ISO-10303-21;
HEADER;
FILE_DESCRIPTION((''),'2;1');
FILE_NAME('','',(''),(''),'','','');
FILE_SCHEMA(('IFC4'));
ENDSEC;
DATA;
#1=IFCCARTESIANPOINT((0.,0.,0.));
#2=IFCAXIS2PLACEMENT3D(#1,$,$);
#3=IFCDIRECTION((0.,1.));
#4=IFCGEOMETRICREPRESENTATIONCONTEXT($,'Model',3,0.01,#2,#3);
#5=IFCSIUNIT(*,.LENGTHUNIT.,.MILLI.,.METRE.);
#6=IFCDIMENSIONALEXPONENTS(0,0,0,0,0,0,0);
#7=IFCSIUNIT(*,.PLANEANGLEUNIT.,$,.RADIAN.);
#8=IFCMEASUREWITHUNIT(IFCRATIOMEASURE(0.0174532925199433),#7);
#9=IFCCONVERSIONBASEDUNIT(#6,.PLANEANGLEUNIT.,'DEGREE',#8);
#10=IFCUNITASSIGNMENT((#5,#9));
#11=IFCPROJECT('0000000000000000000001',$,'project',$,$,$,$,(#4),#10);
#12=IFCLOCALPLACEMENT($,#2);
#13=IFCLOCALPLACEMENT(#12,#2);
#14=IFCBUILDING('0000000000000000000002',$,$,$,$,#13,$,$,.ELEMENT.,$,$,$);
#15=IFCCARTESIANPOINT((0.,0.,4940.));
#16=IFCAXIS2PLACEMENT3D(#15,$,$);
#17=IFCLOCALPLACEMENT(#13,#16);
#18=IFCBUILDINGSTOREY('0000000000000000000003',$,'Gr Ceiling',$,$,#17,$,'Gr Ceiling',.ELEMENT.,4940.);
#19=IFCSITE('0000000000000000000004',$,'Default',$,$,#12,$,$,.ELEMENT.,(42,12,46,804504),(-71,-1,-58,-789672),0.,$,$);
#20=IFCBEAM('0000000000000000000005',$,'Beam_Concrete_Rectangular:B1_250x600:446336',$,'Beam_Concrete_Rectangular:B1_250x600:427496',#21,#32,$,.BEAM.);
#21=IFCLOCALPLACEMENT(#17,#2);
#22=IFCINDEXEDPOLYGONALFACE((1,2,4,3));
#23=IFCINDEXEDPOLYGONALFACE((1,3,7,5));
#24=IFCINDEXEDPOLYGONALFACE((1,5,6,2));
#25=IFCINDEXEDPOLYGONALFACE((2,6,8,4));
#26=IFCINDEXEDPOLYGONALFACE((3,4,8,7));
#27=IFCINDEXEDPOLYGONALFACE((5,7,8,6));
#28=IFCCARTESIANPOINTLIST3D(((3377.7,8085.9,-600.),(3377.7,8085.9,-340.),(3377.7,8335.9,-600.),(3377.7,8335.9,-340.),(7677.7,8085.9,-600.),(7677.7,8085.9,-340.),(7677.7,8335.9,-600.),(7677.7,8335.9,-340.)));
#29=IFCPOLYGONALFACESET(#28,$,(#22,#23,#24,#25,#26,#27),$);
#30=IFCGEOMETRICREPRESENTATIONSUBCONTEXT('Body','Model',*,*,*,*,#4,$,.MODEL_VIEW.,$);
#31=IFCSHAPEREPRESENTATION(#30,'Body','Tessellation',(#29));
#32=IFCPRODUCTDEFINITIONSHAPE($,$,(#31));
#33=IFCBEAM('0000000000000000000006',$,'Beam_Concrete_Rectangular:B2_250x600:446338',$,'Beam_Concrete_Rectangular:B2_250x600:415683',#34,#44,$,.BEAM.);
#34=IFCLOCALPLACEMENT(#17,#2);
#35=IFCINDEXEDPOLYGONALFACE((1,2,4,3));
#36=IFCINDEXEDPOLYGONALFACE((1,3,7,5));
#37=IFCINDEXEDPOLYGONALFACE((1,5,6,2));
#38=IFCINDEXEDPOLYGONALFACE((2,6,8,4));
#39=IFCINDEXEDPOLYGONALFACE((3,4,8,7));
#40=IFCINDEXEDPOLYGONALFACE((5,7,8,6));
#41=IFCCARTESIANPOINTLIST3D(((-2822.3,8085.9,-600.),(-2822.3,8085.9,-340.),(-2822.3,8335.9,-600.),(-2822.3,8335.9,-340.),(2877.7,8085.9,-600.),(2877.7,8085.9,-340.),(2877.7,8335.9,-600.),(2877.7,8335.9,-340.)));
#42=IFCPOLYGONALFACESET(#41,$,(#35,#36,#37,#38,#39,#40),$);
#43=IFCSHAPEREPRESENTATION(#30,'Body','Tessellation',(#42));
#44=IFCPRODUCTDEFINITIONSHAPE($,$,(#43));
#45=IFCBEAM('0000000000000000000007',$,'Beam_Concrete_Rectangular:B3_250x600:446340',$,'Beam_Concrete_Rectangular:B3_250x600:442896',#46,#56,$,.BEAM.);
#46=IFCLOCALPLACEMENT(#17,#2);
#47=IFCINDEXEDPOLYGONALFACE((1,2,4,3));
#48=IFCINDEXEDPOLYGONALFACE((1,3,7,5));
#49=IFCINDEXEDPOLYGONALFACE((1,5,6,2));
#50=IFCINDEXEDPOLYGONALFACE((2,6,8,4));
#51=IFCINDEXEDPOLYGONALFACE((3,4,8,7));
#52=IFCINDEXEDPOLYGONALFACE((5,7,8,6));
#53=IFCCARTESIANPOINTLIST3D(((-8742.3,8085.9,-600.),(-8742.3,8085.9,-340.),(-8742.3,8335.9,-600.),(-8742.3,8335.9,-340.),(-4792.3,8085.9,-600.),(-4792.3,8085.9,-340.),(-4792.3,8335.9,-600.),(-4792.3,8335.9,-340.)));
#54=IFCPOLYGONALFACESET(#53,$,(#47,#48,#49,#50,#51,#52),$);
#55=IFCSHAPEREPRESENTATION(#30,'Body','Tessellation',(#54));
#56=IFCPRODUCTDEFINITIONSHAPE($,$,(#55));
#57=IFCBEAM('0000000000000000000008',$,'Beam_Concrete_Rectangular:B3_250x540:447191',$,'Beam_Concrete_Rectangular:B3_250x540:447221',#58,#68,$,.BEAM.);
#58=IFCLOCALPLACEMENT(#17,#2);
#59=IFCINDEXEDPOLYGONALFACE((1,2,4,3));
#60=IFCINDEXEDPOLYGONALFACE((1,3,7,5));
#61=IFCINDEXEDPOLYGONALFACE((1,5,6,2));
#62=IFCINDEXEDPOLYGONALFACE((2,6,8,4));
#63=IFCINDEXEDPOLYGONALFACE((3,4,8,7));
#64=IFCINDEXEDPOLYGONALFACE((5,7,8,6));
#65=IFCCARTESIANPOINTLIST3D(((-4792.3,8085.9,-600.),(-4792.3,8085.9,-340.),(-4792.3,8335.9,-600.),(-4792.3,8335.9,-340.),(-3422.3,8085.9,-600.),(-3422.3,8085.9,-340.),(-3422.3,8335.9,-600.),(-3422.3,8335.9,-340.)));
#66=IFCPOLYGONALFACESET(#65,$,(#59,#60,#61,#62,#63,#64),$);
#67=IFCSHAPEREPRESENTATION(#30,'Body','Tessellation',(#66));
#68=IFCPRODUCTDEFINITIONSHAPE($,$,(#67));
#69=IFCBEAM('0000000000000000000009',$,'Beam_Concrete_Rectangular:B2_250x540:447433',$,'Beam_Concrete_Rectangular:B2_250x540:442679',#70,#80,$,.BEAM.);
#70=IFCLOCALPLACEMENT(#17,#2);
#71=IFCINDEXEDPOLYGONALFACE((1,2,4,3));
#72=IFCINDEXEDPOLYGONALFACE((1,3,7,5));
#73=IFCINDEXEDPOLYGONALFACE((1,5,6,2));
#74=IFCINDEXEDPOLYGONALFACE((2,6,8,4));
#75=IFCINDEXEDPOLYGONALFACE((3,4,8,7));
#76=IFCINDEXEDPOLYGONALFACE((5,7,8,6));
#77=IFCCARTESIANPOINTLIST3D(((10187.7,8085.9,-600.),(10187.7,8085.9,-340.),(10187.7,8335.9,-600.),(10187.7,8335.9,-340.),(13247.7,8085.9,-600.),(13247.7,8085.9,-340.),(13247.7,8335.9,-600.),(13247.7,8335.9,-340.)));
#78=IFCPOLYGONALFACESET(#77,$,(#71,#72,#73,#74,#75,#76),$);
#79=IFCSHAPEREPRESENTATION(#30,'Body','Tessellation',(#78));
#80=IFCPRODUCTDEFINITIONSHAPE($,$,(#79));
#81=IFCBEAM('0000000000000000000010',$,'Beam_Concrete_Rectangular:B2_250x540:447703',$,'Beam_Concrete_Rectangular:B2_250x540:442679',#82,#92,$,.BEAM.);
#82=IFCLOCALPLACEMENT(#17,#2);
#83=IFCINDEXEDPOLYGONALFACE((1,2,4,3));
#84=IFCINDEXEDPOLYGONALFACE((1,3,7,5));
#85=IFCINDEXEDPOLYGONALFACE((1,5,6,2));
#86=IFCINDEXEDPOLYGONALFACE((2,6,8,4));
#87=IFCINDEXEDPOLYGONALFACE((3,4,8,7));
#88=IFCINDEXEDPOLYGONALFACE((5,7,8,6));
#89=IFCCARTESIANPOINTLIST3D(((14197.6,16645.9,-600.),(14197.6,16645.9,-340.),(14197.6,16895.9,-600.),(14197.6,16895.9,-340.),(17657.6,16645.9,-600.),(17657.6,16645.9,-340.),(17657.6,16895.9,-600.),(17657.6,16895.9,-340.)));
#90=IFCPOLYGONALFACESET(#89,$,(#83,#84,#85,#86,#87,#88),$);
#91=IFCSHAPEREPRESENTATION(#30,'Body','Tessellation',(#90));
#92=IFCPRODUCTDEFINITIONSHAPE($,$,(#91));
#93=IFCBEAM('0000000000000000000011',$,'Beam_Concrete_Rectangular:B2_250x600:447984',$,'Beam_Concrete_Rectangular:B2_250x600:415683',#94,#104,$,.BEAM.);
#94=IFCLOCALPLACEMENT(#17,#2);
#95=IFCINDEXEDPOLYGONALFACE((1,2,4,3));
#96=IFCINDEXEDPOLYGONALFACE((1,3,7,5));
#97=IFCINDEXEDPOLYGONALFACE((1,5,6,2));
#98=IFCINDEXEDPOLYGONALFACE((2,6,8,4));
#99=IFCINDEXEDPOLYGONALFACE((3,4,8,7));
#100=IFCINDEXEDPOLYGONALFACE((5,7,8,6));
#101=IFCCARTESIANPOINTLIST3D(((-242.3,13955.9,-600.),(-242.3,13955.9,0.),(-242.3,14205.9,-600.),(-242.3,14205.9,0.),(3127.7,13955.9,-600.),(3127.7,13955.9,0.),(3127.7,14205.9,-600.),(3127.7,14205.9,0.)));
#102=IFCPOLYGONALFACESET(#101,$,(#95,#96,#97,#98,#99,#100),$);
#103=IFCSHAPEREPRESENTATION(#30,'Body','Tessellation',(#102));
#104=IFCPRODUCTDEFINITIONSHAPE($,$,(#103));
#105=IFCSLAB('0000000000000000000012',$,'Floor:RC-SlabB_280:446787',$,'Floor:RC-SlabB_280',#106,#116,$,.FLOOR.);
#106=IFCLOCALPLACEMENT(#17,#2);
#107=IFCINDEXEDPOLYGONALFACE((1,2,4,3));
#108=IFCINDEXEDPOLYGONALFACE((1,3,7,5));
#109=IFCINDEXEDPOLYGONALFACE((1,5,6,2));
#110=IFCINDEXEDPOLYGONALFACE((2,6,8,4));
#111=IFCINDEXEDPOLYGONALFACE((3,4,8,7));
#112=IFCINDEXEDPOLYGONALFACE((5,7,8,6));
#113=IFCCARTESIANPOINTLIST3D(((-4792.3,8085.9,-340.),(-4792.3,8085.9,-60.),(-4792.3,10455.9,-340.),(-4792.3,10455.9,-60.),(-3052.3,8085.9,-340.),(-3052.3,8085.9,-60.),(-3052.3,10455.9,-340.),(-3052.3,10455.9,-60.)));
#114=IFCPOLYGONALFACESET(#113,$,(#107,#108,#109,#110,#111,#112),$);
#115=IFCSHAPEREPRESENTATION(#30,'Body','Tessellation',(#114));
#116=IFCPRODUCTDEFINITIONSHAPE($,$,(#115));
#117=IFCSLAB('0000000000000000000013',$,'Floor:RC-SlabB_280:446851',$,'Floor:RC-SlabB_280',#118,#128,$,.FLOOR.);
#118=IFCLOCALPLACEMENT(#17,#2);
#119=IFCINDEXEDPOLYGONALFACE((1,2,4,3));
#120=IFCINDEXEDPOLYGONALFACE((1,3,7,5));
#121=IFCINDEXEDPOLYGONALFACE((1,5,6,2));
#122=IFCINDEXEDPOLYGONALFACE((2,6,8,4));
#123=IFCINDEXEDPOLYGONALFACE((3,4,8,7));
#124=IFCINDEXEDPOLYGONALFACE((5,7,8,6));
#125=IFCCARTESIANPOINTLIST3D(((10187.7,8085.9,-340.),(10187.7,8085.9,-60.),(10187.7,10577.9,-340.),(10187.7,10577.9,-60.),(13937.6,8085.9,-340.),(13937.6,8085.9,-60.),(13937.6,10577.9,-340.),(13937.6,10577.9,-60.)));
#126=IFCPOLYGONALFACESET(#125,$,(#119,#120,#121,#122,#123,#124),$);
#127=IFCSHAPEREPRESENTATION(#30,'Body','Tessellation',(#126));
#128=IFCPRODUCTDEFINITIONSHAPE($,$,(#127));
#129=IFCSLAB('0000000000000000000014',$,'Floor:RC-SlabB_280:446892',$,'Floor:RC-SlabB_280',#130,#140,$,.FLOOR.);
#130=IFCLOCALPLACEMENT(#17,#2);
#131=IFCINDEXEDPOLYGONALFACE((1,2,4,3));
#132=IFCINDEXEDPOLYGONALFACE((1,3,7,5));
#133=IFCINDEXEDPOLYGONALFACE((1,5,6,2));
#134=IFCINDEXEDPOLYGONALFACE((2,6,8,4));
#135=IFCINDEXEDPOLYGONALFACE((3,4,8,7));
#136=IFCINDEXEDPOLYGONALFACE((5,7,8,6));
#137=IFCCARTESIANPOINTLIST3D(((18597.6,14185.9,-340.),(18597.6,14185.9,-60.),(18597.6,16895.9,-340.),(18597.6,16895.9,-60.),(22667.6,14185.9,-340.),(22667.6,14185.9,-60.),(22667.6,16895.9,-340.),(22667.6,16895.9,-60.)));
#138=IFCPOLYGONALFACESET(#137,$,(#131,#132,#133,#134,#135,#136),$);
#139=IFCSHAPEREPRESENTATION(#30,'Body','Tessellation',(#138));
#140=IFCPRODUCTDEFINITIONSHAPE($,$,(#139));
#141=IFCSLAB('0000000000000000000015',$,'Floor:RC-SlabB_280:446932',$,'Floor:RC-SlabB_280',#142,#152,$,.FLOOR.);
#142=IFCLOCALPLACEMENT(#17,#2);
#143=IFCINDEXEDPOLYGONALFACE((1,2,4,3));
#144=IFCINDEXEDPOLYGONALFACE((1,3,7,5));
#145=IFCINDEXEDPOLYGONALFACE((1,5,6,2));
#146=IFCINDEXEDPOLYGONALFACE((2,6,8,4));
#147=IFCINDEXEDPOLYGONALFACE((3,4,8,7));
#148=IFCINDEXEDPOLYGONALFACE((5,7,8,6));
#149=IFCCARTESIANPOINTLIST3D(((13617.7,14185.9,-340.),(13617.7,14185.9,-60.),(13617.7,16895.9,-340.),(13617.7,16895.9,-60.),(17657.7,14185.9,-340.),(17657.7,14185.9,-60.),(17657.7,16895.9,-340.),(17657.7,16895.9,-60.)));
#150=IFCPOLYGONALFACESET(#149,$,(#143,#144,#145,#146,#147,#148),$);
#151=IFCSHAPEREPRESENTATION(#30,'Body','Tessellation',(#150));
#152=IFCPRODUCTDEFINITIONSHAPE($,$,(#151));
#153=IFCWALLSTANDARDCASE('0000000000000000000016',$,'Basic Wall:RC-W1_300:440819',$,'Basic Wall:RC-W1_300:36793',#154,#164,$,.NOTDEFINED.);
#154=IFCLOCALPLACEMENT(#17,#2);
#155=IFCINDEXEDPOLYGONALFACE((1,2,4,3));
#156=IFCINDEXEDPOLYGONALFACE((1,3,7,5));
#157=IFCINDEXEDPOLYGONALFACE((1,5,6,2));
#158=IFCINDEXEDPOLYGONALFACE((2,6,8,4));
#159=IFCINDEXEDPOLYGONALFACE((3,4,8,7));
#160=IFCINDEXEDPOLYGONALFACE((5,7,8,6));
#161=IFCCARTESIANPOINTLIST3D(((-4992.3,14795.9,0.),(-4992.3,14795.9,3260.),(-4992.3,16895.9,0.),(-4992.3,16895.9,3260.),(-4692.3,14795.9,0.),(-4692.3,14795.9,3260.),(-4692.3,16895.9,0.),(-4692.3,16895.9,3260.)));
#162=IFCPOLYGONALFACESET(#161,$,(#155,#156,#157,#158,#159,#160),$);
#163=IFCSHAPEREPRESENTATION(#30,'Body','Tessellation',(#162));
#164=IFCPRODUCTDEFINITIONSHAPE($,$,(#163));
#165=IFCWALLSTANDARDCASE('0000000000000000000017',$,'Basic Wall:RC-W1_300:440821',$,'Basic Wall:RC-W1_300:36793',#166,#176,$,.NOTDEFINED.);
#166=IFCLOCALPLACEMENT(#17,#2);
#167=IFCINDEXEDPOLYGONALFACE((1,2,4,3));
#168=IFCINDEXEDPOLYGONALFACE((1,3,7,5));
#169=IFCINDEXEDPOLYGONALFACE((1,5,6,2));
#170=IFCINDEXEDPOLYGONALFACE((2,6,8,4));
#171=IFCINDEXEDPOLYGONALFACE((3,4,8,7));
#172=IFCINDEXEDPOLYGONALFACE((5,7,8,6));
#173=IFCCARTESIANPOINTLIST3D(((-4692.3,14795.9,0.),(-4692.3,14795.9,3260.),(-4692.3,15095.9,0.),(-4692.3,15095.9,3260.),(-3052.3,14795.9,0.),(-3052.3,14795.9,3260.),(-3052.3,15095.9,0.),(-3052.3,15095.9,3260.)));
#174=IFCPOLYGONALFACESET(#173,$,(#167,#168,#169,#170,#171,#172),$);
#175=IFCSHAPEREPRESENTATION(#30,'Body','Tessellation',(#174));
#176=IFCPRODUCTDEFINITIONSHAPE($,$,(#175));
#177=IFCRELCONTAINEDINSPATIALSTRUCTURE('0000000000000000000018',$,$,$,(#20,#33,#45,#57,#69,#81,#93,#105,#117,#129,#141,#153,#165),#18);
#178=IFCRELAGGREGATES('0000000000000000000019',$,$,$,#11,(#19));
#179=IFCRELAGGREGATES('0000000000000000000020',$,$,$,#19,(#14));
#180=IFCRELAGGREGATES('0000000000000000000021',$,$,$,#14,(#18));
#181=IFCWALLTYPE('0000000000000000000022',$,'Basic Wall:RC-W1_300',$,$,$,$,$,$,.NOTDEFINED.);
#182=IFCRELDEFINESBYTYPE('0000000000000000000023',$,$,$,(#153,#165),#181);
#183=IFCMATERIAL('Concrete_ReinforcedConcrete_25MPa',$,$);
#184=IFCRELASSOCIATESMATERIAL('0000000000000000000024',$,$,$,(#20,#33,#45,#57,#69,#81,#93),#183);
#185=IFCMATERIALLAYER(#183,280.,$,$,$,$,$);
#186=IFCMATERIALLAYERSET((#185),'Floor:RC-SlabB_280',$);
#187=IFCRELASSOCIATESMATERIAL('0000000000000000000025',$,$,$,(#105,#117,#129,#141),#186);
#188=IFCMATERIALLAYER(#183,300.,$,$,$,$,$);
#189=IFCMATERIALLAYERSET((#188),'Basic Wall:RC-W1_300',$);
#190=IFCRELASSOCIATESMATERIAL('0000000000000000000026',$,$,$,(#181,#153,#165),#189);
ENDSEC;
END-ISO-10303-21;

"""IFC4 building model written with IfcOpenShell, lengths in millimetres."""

from ifc_helpers import new_model, entity, si_unit, converted_unit, direction, frame, frame_2d, origin, origin_2d_with_axis, place, context, subcontext, project, spatial, rectangle, extrude, material, layer, layer_set, layer_usage, type_object, element, save


model = new_model("IFC4")

# Units and contexts
model_context = context("Model", 3, precision=0.01, world=origin(), true_north=direction((0.0, 1.0)))
body_context = subcontext(model_context, "Body", "Model", "MODEL_VIEW")
ifc_project = project(units=[si_unit("LENGTHUNIT", "METRE", prefix="MILLI"), converted_unit("PLANEANGLEUNIT", "DEGREE", entity("IfcRatioMeasure", 0.0174532925199433), si_unit("PLANEANGLEUNIT", "RADIAN"), dimensions=[0, 0, 0, 0, 0, 0, 0])], contexts=[model_context])

# Site, building, storey
site_placement = place(None, origin())
site = spatial("IfcSite", under=ifc_project, at=site_placement, Name="Default", CompositionType="ELEMENT", RefLatitude=(42, 12, 46, 804504), RefLongitude=(-71, -1, -58, -789672), RefElevation=0.0)
building_placement = place(site_placement, origin())
building = spatial("IfcBuilding", under=site, at=building_placement, CompositionType="ELEMENT")
storey_placement = place(building_placement, frame((0.0, 0.0, 4940.0)))
storey = spatial("IfcBuildingStorey", under=building, at=storey_placement, Name="Gr Ceiling", LongName="Gr Ceiling", CompositionType="ELEMENT", Elevation=4940.0)

# Shared definitions
ifc_material = material(Name="Concrete_ReinforcedConcrete_25MPa")

# Beams
beam_1_placement = place(storey_placement, frame((3127.7, 8085.9, 0.0)))
element("IfcBeam", 1, at=beam_1_placement, inside=storey, material=ifc_material, Name="Beam_Concrete_Rectangular:B1_250x600:446336", ObjectType="Beam_Concrete_Rectangular:B1_250x600:427496", PredefinedType="BEAM", context=body_context, shape_type="SweptSolid", body=[
    extrude(rectangle(XDim=260.0, YDim=250.0, at=frame_2d((0.0, 0.0), x_axis=(1.0, 0.0))), frame((250.0, 125.0, -470.0), z_axis=(1.0, 0.0, 0.0), x_axis=(0.0, 0.0, -1.0)), (0.0, 0.0, 1.0), 4300.0),
])
beam_2_placement = place(storey_placement, frame((-3122.3, 8085.9, 0.0)))
element("IfcBeam", 2, at=beam_2_placement, inside=storey, material=ifc_material, Name="Beam_Concrete_Rectangular:B2_250x600:446338", ObjectType="Beam_Concrete_Rectangular:B2_250x600:415683", PredefinedType="BEAM", context=body_context, shape_type="SweptSolid", body=[
    extrude(rectangle(XDim=260.0, YDim=250.0, at=frame_2d((0.0, 0.0), x_axis=(1.0, 0.0))), frame((300.0, 125.0, -470.0), z_axis=(1.0, 0.0, 0.0), x_axis=(0.0, 0.0, -1.0)), (0.0, 0.0, 1.0), 5700.0),
])
beam_3_placement = place(storey_placement, frame((-8992.3, 8085.9, 0.0)))
element("IfcBeam", 3, at=beam_3_placement, inside=storey, material=ifc_material, Name="Beam_Concrete_Rectangular:B3_250x600:446340", ObjectType="Beam_Concrete_Rectangular:B3_250x600:442896", PredefinedType="BEAM", context=body_context, shape_type="SweptSolid", body=[
    extrude(rectangle(XDim=260.0, YDim=250.0, at=frame_2d((0.0, 0.0), x_axis=(1.0, 0.0))), frame((250.0, 125.0, -470.0), z_axis=(1.0, 0.0, 0.0), x_axis=(0.0, 0.0, -1.0)), (0.0, 0.0, 1.0), 3950.0),
])
beam_4_placement = place(storey_placement, frame((-4792.3, 8085.9, 0.0)))
element("IfcBeam", 4, at=beam_4_placement, inside=storey, material=ifc_material, Name="Beam_Concrete_Rectangular:B3_250x540:447191", ObjectType="Beam_Concrete_Rectangular:B3_250x540:447221", PredefinedType="BEAM", context=body_context, shape_type="SweptSolid", body=[
    extrude(rectangle(XDim=260.0, YDim=250.0, at=frame_2d((0.0, 0.0), x_axis=(1.0, 0.0))), frame((0.0, 125.0, -470.0), z_axis=(1.0, 0.0, 0.0), x_axis=(0.0, 0.0, -1.0)), (0.0, 0.0, 1.0), 1370.0),
])
beam_5_placement = place(storey_placement, frame((10187.7, 8085.9, 0.0)))
element("IfcBeam", 5, at=beam_5_placement, inside=storey, material=ifc_material, Name="Beam_Concrete_Rectangular:B2_250x540:447433", ObjectType="Beam_Concrete_Rectangular:B2_250x540:442679", PredefinedType="BEAM", context=body_context, shape_type="SweptSolid", body=[
    extrude(rectangle(XDim=260.0, YDim=250.0, at=frame_2d((0.0, 0.0), x_axis=(1.0, 0.0))), frame((0.0, 125.0, -470.0), z_axis=(1.0, 0.0, 0.0), x_axis=(0.0, 0.0, -1.0)), (0.0, 0.0, 1.0), 3060.0),
])
beam_6_placement = place(storey_placement, frame((17657.6, 16895.9, 0.0), z_axis=(0.0, 0.0, 1.0), x_axis=(-1.0, 0.0, 0.0)))
element("IfcBeam", 6, at=beam_6_placement, inside=storey, material=ifc_material, Name="Beam_Concrete_Rectangular:B2_250x540:447703", ObjectType="Beam_Concrete_Rectangular:B2_250x540:442679", PredefinedType="BEAM", context=body_context, shape_type="SweptSolid", body=[
    extrude(rectangle(XDim=260.0, YDim=250.0, at=frame_2d((0.0, 0.0), x_axis=(1.0, 0.0))), frame((0.0, 125.0, -470.0), z_axis=(1.0, 0.0, 0.0), x_axis=(0.0, 0.0, -1.0)), (0.0, 0.0, 1.0), 3460.0),
])
beam_7_placement = place(storey_placement, frame((3252.7, 14205.9, 0.0), z_axis=(0.0, 0.0, 1.0), x_axis=(-1.0, 0.0, 0.0)))
element("IfcBeam", 7, at=beam_7_placement, inside=storey, material=ifc_material, Name="Beam_Concrete_Rectangular:B2_250x600:447984", ObjectType="Beam_Concrete_Rectangular:B2_250x600:415683", PredefinedType="BEAM", context=body_context, shape_type="SweptSolid", body=[
    extrude(rectangle(XDim=600.0, YDim=250.0, at=frame_2d((0.0, 0.0), x_axis=(1.0, 0.0))), frame((125.0, 125.0, -300.0), z_axis=(1.0, 0.0, 0.0), x_axis=(0.0, 0.0, -1.0)), (0.0, 0.0, 1.0), 3370.0),
])

# Slabs
ifc_layer_1 = layer(ifc_material, 280.0)
ifc_layer_set_1 = layer_set([ifc_layer_1], Name="Floor:RC-SlabB_280")
ifc_layer_usage_1 = layer_usage(ifc_layer_set_1, "AXIS3", "POSITIVE", 0.0)
slab_1_placement = place(storey_placement, origin())
element("IfcSlab", 8, at=slab_1_placement, inside=storey, material=ifc_layer_usage_1, Name="Floor:RC-SlabB_280:446787", ObjectType="Floor:RC-SlabB_280", PredefinedType="FLOOR", context=body_context, shape_type="SweptSolid", body=[
    extrude(rectangle(XDim=2370.0, YDim=1740.0, at=frame_2d((0.0, 0.0), x_axis=(1.0, 0.0))), frame((-3922.3, 9270.9, -60.0), z_axis=(0.0, 0.0, -1.0), x_axis=(0.0, 1.0, 0.0)), (0.0, 0.0, 1.0), 280.0),
])
ifc_layer_usage_2 = layer_usage(ifc_layer_set_1, "AXIS3", "POSITIVE", 0.0)
slab_2_placement = place(storey_placement, origin())
element("IfcSlab", 9, at=slab_2_placement, inside=storey, material=ifc_layer_usage_2, Name="Floor:RC-SlabB_280:446851", ObjectType="Floor:RC-SlabB_280", PredefinedType="FLOOR", context=body_context, shape_type="SweptSolid", body=[
    extrude(rectangle(XDim=2492.0, YDim=3750.0, at=frame_2d((0.0, 0.0), x_axis=(1.0, 0.0))), frame((12062.6, 9331.9, -60.0), z_axis=(0.0, 0.0, -1.0), x_axis=(0.0, 1.0, 0.0)), (0.0, 0.0, 1.0), 280.0),
])
ifc_layer_usage_3 = layer_usage(ifc_layer_set_1, "AXIS3", "POSITIVE", 0.0)
slab_3_placement = place(storey_placement, origin())
element("IfcSlab", 10, at=slab_3_placement, inside=storey, material=ifc_layer_usage_3, Name="Floor:RC-SlabB_280:446892", ObjectType="Floor:RC-SlabB_280", PredefinedType="FLOOR", context=body_context, shape_type="SweptSolid", body=[
    extrude(rectangle(XDim=2710.0, YDim=4070.0, at=frame_2d((0.0, 0.0), x_axis=(1.0, 0.0))), frame((20632.6, 15540.9, -60.0), z_axis=(0.0, 0.0, -1.0), x_axis=(0.0, 1.0, 0.0)), (0.0, 0.0, 1.0), 280.0),
])
ifc_layer_usage_4 = layer_usage(ifc_layer_set_1, "AXIS3", "POSITIVE", 0.0)
slab_4_placement = place(storey_placement, origin())
element("IfcSlab", 11, at=slab_4_placement, inside=storey, material=ifc_layer_usage_4, Name="Floor:RC-SlabB_280:446932", ObjectType="Floor:RC-SlabB_280", PredefinedType="FLOOR", context=body_context, shape_type="SweptSolid", body=[
    extrude(rectangle(XDim=2710.0, YDim=4040.0, at=origin_2d_with_axis()), frame((15637.7, 15540.9, -60.0), z_axis=(0.0, 0.0, -1.0), x_axis=(0.0, 1.0, 0.0)), (0.0, 0.0, 1.0), 280.0),
])

# Walls
ifc_layer_2 = layer(ifc_material, 300.0)
ifc_layer_set_2 = layer_set([ifc_layer_2], Name="Basic Wall:RC-W1_300")
ifc_layer_usage_5 = layer_usage(ifc_layer_set_2, "AXIS2", "NEGATIVE", 150.0)
wall_type_1 = type_object("IfcWallType", Name="Basic Wall:RC-W1_300", PredefinedType="NOTDEFINED", material=ifc_layer_set_2)
wall_1_placement = place(storey_placement, frame((-4842.3, 16895.9, 0.0), z_axis=(0.0, 0.0, 1.0), x_axis=(0.0, -1.0, 0.0)))
element("IfcWallStandardCase", 12, at=wall_1_placement, inside=storey, type_object=wall_type_1, material=ifc_layer_usage_5, Name="Basic Wall:RC-W1_300:440819", ObjectType="Basic Wall:RC-W1_300:36793", PredefinedType="NOTDEFINED", context=body_context, shape_type="SweptSolid", body=[
    extrude(rectangle(XDim=2100.0, YDim=300.0, at=frame_2d((1050.0, 0.0), x_axis=(-1.0, 0.0))), origin(), (0.0, 0.0, 1.0), 3260.0),
])
ifc_layer_usage_6 = layer_usage(ifc_layer_set_2, "AXIS2", "NEGATIVE", 150.0)
wall_2_placement = place(storey_placement, frame((-4692.3, 14945.9, 0.0)))
element("IfcWallStandardCase", 13, at=wall_2_placement, inside=storey, type_object=wall_type_1, material=ifc_layer_usage_6, Name="Basic Wall:RC-W1_300:440821", ObjectType="Basic Wall:RC-W1_300:36793", PredefinedType="NOTDEFINED", context=body_context, shape_type="SweptSolid", body=[
    extrude(rectangle(XDim=1640.0, YDim=300.0, at=frame_2d((820.0, 0.0), x_axis=(-1.0, 0.0))), origin(), (0.0, 0.0, 1.0), 3260.0),
])

save(model, "model.ifc")
